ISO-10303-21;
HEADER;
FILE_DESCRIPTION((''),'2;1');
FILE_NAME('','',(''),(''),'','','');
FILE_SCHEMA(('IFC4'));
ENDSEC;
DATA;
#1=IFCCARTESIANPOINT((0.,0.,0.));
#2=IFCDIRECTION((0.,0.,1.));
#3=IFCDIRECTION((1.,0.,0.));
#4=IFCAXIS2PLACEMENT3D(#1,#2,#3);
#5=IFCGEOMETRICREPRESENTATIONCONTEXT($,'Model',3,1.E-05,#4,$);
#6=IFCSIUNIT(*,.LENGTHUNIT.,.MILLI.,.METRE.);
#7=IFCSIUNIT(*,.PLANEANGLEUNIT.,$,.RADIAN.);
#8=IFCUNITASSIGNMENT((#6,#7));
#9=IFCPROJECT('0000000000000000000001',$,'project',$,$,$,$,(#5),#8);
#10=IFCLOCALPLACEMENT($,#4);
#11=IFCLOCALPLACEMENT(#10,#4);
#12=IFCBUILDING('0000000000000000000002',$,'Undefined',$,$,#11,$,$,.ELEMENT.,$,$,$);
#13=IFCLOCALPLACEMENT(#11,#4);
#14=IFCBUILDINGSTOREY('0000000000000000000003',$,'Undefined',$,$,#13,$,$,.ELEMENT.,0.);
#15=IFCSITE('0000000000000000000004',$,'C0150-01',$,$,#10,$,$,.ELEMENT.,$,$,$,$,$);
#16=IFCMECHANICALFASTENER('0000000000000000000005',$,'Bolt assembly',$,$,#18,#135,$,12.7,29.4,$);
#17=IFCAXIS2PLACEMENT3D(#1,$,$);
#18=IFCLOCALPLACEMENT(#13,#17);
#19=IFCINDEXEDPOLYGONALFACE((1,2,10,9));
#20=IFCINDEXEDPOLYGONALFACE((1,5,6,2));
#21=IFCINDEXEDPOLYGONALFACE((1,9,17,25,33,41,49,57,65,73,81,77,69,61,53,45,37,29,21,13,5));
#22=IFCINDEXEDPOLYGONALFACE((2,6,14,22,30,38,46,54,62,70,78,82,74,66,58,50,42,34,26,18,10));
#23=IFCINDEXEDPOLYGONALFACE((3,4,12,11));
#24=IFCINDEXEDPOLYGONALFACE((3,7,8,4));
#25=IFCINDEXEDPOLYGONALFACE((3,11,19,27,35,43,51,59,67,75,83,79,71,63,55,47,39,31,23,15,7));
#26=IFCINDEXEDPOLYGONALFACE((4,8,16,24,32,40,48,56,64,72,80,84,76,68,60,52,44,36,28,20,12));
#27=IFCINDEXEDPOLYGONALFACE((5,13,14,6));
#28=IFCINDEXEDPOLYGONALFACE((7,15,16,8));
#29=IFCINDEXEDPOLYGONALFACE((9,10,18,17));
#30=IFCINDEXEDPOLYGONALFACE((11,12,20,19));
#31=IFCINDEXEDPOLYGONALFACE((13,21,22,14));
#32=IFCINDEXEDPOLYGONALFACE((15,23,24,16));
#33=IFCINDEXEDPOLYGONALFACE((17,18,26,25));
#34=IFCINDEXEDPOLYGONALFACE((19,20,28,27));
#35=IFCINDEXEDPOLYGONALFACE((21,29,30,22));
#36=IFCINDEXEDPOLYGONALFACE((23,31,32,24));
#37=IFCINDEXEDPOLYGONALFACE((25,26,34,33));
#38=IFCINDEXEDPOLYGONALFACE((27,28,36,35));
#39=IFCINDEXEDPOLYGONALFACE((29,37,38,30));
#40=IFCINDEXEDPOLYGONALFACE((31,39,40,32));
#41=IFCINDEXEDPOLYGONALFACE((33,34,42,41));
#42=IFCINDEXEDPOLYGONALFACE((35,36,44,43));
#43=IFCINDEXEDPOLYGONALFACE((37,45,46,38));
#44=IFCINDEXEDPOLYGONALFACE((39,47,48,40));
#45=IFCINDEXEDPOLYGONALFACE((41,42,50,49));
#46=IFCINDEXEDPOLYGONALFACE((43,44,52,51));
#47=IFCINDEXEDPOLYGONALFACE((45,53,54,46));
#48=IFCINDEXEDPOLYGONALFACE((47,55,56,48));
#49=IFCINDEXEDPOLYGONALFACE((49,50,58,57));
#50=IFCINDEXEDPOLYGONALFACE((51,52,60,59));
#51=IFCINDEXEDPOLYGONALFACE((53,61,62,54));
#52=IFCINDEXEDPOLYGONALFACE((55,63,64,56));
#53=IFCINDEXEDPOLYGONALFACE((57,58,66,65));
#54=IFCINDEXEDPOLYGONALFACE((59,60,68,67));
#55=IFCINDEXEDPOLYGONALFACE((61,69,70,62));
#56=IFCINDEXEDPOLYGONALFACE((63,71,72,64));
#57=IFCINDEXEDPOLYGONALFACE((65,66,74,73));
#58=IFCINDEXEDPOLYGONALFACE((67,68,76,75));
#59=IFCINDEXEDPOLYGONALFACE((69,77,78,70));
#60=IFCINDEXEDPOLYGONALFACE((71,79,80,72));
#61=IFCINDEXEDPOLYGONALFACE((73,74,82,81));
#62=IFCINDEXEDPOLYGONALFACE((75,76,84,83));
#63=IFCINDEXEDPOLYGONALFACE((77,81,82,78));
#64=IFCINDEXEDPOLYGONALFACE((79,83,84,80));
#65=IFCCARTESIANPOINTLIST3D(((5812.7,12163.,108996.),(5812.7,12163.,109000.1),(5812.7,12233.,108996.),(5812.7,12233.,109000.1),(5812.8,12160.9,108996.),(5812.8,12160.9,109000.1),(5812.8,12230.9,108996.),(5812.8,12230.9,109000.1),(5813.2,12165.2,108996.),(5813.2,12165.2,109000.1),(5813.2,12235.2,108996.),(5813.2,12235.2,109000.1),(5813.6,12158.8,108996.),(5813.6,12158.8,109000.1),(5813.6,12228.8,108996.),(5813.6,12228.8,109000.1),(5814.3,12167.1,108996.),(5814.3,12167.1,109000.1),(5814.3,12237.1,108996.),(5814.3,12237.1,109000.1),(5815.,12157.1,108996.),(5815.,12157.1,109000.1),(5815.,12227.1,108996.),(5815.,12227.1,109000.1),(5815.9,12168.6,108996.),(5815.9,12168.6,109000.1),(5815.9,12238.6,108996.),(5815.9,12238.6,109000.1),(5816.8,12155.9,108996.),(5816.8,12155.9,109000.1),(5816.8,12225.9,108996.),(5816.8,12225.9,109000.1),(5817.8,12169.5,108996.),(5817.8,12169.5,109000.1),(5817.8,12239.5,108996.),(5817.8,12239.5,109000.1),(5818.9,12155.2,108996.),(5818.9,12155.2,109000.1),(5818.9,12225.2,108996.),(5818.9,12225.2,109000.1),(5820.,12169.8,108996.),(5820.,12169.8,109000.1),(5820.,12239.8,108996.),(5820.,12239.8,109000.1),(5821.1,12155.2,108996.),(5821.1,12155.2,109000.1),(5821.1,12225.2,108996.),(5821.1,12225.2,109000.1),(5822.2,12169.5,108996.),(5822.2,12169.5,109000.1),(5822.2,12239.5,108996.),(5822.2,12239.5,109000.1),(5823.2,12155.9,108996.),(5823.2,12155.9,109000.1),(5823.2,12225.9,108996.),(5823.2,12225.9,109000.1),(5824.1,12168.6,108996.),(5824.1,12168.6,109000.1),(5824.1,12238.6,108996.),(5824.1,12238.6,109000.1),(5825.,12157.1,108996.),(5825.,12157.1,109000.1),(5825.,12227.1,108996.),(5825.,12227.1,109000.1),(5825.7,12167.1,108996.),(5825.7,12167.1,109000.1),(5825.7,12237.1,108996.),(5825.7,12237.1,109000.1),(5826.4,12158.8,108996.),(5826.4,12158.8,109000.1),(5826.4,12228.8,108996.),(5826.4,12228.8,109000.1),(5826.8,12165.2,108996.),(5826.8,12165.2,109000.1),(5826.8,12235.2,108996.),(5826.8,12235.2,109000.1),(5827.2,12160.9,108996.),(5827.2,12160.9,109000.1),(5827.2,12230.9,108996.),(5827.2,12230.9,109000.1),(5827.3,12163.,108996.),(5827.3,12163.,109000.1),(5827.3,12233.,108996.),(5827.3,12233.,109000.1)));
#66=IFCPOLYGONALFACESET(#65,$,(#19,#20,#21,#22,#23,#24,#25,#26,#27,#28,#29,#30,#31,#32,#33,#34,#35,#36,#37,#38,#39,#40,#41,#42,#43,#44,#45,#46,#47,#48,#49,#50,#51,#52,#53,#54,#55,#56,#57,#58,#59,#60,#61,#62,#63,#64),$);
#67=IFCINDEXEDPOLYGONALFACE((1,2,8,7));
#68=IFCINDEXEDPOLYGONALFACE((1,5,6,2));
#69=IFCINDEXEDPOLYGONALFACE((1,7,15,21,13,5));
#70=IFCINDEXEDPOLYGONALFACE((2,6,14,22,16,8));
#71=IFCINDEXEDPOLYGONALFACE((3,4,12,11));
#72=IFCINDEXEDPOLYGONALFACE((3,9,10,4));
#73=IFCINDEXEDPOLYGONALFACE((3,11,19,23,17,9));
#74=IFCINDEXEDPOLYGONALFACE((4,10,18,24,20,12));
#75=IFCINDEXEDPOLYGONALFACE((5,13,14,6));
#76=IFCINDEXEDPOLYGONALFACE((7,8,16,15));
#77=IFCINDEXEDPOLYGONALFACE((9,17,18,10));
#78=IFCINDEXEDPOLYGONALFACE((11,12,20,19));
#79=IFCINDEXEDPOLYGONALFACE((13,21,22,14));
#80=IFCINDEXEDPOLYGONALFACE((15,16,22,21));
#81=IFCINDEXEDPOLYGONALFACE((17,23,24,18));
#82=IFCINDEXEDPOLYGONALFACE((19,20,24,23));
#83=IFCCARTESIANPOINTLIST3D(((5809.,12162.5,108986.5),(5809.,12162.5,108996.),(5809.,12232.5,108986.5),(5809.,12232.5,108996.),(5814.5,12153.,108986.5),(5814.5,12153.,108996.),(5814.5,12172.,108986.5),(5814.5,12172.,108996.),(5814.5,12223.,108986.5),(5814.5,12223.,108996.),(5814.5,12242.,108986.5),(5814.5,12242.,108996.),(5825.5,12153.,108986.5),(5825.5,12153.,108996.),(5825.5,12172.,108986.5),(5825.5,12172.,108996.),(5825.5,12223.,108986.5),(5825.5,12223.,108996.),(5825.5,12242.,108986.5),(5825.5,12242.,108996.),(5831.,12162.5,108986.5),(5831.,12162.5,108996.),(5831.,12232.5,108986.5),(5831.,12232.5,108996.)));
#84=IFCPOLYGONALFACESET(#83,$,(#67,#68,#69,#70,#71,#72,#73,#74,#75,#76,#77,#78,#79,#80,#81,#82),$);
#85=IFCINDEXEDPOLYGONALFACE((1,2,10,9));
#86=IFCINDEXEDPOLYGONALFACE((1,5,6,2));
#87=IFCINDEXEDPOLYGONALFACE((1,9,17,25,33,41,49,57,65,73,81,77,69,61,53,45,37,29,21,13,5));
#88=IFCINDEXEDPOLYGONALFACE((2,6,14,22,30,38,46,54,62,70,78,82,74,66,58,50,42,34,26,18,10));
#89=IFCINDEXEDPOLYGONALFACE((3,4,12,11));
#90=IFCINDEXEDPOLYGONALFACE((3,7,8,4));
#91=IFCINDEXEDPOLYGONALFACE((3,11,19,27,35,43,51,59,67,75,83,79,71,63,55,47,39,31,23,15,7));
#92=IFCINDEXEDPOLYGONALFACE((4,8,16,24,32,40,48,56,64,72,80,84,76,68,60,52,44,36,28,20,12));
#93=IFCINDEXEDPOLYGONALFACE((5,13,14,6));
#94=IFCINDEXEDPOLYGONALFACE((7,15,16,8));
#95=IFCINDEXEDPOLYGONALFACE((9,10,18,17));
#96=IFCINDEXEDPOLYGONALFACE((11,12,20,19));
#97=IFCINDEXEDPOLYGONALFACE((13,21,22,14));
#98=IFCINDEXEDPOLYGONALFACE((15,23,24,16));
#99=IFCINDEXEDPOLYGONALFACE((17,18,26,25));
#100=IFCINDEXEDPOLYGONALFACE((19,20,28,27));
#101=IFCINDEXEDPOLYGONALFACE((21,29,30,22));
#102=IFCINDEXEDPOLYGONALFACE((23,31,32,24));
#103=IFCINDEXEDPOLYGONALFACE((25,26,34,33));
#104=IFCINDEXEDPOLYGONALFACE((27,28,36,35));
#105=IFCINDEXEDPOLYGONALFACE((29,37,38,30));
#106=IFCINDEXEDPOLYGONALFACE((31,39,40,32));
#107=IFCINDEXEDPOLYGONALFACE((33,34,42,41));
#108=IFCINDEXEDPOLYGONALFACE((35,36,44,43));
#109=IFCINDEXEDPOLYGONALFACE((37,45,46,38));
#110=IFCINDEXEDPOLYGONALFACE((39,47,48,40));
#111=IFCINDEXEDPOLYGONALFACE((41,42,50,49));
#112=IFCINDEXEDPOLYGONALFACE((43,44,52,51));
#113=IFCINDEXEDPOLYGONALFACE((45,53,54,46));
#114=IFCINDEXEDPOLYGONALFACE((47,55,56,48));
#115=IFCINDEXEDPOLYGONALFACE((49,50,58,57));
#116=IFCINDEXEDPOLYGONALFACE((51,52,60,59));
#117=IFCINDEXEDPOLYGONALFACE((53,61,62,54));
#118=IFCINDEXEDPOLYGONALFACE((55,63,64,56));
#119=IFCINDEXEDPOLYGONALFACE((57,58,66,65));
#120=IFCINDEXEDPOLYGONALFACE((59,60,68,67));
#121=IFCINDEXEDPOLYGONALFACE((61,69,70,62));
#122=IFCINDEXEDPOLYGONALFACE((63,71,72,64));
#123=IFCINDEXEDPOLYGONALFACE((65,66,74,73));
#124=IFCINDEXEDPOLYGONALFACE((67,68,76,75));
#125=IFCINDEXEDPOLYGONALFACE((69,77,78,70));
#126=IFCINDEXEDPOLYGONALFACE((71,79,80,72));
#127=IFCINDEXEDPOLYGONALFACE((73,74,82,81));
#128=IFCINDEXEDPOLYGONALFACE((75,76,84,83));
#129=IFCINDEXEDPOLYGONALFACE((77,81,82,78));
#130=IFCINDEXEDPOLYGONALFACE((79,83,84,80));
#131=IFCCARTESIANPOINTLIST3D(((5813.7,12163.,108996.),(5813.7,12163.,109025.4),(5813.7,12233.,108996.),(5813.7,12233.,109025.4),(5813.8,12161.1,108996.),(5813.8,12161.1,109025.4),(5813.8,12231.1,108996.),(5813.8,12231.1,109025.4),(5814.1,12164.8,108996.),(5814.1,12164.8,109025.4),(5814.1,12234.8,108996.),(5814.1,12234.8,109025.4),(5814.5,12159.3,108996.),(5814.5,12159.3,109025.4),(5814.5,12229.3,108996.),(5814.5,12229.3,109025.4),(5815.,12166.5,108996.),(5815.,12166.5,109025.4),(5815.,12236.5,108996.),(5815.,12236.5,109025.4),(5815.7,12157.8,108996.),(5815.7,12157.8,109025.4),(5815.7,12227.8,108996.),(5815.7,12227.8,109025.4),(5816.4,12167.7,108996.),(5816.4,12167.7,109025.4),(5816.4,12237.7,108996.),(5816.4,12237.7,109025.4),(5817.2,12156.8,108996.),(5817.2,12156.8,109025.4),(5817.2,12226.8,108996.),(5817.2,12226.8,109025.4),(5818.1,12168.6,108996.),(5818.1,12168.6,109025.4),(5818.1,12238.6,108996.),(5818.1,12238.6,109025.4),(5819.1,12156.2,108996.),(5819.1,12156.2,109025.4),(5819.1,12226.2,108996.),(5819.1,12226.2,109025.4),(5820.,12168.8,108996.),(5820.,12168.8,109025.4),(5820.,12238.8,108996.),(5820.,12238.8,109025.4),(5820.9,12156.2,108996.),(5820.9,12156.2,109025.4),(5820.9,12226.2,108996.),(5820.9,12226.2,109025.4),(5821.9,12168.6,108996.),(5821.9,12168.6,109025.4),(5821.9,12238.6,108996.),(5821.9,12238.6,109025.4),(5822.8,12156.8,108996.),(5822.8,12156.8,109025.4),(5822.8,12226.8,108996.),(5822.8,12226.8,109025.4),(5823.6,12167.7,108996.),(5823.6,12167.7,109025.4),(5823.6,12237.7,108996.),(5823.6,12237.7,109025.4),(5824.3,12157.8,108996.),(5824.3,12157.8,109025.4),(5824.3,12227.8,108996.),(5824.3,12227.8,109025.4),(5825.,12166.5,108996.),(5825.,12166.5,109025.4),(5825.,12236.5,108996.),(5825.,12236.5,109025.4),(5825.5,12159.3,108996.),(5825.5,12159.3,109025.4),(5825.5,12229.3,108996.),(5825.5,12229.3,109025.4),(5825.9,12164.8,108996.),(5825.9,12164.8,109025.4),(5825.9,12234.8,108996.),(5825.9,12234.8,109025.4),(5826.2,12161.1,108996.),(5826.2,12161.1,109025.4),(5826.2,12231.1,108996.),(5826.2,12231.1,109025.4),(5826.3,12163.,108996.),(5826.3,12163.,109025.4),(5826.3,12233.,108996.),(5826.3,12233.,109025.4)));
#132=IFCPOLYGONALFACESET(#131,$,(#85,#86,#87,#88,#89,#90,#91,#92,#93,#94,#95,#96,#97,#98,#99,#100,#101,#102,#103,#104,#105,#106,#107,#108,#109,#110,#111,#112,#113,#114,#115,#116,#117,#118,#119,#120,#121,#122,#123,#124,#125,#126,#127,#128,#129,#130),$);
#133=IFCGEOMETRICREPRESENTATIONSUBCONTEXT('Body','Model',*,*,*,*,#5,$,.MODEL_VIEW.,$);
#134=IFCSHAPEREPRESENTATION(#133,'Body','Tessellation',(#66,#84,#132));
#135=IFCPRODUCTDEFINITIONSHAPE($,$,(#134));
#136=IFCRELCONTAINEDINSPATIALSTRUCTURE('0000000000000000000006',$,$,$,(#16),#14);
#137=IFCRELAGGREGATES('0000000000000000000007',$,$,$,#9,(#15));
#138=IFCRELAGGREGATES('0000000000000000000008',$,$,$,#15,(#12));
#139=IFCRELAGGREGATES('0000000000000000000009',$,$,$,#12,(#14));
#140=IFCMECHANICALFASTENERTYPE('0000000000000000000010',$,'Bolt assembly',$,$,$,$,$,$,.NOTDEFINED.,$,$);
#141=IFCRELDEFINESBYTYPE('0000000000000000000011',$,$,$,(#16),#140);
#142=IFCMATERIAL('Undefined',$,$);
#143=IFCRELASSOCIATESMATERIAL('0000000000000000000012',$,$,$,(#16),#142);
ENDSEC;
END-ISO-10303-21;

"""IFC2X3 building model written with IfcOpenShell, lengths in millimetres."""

from ifc_helpers import new_model, si_unit, frame, origin_with_axes, origin_2d_with_axis, place, context, subcontext, project, spatial, polyline, circle, outline, extrude, source, transform, mapped, material, type_object, element, save


model = new_model("IFC2X3")

# Units and contexts
model_context = context("Model", 3, precision=1e-05, world=origin_with_axes())
body_context = subcontext(model_context, "Body", "Model", "MODEL_VIEW")
ifc_project = project(units=[si_unit("LENGTHUNIT", "METRE", prefix="MILLI"), si_unit("PLANEANGLEUNIT", "RADIAN")], contexts=[model_context])

# Site, building, storey
site_placement = place(None, origin_with_axes())
site = spatial("IfcSite", under=ifc_project, at=site_placement, Name="C0150-01", CompositionType="ELEMENT")
building_placement = place(site_placement, origin_with_axes())
building = spatial("IfcBuilding", under=site, at=building_placement, Name="Undefined", CompositionType="ELEMENT")
storey_placement = place(building_placement, origin_with_axes())
storey = spatial("IfcBuildingStorey", under=building, at=storey_placement, Name="Undefined", CompositionType="ELEMENT", Elevation=0.0)

# Mechanical fastener
ifc_material_1 = material(Name="Undefined")
mechanical_fastener_type = type_object("IfcMechanicalFastenerType", Name="Bolt assembly")
shared_shape_1 = source(origin_with_axes(), body_context, "Body", "SweptSolid", [
    extrude(circle(Radius=7.3, at=origin_2d_with_axis()), frame((0.0, 0.0, 0.0), z_axis=(0.0, 1.0, 0.0), x_axis=(1.0, 0.0, 0.0)), (0.0, 0.0, 1.0), 4.1),
    extrude(outline(polyline([(9.5, -5.5), (9.5, 5.5), (0.0, 11.0), (-9.5, 5.5), (-9.5, -5.5), (0.0, -11.0), (9.5, -5.5)])), frame((0.0, -9.5, 0.0), z_axis=(0.0, 1.0, 0.0), x_axis=(1.0, 0.0, 0.0)), (0.0, 0.0, 1.0), 9.5),
    extrude(circle(Radius=6.3, at=origin_2d_with_axis()), frame((0.0, 0.0, 0.0), z_axis=(0.0, 1.0, 0.0), x_axis=(1.0, 0.0, 0.0)), (0.0, 0.0, 1.0), 29.4),
])
mechanical_fastener_1_placement = place(storey_placement, frame((5820.0, 12162.5, 108996.0), z_axis=(1.0, 0.0, 0.0), x_axis=(0.0, 1.0, 0.0)))
element("IfcMechanicalFastener", 1, at=mechanical_fastener_1_placement, inside=storey, type_object=mechanical_fastener_type, material=ifc_material_1, Name="Bolt assembly", NominalDiameter=12.7, NominalLength=29.4, context=body_context, shape_type="MappedRepresentation", body=[
    mapped(shared_shape_1, transform((0.0, 0.0, 0.0))),
    mapped(shared_shape_1, transform((70.0, 0.0, 0.0))),
])

save(model, "model.ifc")
